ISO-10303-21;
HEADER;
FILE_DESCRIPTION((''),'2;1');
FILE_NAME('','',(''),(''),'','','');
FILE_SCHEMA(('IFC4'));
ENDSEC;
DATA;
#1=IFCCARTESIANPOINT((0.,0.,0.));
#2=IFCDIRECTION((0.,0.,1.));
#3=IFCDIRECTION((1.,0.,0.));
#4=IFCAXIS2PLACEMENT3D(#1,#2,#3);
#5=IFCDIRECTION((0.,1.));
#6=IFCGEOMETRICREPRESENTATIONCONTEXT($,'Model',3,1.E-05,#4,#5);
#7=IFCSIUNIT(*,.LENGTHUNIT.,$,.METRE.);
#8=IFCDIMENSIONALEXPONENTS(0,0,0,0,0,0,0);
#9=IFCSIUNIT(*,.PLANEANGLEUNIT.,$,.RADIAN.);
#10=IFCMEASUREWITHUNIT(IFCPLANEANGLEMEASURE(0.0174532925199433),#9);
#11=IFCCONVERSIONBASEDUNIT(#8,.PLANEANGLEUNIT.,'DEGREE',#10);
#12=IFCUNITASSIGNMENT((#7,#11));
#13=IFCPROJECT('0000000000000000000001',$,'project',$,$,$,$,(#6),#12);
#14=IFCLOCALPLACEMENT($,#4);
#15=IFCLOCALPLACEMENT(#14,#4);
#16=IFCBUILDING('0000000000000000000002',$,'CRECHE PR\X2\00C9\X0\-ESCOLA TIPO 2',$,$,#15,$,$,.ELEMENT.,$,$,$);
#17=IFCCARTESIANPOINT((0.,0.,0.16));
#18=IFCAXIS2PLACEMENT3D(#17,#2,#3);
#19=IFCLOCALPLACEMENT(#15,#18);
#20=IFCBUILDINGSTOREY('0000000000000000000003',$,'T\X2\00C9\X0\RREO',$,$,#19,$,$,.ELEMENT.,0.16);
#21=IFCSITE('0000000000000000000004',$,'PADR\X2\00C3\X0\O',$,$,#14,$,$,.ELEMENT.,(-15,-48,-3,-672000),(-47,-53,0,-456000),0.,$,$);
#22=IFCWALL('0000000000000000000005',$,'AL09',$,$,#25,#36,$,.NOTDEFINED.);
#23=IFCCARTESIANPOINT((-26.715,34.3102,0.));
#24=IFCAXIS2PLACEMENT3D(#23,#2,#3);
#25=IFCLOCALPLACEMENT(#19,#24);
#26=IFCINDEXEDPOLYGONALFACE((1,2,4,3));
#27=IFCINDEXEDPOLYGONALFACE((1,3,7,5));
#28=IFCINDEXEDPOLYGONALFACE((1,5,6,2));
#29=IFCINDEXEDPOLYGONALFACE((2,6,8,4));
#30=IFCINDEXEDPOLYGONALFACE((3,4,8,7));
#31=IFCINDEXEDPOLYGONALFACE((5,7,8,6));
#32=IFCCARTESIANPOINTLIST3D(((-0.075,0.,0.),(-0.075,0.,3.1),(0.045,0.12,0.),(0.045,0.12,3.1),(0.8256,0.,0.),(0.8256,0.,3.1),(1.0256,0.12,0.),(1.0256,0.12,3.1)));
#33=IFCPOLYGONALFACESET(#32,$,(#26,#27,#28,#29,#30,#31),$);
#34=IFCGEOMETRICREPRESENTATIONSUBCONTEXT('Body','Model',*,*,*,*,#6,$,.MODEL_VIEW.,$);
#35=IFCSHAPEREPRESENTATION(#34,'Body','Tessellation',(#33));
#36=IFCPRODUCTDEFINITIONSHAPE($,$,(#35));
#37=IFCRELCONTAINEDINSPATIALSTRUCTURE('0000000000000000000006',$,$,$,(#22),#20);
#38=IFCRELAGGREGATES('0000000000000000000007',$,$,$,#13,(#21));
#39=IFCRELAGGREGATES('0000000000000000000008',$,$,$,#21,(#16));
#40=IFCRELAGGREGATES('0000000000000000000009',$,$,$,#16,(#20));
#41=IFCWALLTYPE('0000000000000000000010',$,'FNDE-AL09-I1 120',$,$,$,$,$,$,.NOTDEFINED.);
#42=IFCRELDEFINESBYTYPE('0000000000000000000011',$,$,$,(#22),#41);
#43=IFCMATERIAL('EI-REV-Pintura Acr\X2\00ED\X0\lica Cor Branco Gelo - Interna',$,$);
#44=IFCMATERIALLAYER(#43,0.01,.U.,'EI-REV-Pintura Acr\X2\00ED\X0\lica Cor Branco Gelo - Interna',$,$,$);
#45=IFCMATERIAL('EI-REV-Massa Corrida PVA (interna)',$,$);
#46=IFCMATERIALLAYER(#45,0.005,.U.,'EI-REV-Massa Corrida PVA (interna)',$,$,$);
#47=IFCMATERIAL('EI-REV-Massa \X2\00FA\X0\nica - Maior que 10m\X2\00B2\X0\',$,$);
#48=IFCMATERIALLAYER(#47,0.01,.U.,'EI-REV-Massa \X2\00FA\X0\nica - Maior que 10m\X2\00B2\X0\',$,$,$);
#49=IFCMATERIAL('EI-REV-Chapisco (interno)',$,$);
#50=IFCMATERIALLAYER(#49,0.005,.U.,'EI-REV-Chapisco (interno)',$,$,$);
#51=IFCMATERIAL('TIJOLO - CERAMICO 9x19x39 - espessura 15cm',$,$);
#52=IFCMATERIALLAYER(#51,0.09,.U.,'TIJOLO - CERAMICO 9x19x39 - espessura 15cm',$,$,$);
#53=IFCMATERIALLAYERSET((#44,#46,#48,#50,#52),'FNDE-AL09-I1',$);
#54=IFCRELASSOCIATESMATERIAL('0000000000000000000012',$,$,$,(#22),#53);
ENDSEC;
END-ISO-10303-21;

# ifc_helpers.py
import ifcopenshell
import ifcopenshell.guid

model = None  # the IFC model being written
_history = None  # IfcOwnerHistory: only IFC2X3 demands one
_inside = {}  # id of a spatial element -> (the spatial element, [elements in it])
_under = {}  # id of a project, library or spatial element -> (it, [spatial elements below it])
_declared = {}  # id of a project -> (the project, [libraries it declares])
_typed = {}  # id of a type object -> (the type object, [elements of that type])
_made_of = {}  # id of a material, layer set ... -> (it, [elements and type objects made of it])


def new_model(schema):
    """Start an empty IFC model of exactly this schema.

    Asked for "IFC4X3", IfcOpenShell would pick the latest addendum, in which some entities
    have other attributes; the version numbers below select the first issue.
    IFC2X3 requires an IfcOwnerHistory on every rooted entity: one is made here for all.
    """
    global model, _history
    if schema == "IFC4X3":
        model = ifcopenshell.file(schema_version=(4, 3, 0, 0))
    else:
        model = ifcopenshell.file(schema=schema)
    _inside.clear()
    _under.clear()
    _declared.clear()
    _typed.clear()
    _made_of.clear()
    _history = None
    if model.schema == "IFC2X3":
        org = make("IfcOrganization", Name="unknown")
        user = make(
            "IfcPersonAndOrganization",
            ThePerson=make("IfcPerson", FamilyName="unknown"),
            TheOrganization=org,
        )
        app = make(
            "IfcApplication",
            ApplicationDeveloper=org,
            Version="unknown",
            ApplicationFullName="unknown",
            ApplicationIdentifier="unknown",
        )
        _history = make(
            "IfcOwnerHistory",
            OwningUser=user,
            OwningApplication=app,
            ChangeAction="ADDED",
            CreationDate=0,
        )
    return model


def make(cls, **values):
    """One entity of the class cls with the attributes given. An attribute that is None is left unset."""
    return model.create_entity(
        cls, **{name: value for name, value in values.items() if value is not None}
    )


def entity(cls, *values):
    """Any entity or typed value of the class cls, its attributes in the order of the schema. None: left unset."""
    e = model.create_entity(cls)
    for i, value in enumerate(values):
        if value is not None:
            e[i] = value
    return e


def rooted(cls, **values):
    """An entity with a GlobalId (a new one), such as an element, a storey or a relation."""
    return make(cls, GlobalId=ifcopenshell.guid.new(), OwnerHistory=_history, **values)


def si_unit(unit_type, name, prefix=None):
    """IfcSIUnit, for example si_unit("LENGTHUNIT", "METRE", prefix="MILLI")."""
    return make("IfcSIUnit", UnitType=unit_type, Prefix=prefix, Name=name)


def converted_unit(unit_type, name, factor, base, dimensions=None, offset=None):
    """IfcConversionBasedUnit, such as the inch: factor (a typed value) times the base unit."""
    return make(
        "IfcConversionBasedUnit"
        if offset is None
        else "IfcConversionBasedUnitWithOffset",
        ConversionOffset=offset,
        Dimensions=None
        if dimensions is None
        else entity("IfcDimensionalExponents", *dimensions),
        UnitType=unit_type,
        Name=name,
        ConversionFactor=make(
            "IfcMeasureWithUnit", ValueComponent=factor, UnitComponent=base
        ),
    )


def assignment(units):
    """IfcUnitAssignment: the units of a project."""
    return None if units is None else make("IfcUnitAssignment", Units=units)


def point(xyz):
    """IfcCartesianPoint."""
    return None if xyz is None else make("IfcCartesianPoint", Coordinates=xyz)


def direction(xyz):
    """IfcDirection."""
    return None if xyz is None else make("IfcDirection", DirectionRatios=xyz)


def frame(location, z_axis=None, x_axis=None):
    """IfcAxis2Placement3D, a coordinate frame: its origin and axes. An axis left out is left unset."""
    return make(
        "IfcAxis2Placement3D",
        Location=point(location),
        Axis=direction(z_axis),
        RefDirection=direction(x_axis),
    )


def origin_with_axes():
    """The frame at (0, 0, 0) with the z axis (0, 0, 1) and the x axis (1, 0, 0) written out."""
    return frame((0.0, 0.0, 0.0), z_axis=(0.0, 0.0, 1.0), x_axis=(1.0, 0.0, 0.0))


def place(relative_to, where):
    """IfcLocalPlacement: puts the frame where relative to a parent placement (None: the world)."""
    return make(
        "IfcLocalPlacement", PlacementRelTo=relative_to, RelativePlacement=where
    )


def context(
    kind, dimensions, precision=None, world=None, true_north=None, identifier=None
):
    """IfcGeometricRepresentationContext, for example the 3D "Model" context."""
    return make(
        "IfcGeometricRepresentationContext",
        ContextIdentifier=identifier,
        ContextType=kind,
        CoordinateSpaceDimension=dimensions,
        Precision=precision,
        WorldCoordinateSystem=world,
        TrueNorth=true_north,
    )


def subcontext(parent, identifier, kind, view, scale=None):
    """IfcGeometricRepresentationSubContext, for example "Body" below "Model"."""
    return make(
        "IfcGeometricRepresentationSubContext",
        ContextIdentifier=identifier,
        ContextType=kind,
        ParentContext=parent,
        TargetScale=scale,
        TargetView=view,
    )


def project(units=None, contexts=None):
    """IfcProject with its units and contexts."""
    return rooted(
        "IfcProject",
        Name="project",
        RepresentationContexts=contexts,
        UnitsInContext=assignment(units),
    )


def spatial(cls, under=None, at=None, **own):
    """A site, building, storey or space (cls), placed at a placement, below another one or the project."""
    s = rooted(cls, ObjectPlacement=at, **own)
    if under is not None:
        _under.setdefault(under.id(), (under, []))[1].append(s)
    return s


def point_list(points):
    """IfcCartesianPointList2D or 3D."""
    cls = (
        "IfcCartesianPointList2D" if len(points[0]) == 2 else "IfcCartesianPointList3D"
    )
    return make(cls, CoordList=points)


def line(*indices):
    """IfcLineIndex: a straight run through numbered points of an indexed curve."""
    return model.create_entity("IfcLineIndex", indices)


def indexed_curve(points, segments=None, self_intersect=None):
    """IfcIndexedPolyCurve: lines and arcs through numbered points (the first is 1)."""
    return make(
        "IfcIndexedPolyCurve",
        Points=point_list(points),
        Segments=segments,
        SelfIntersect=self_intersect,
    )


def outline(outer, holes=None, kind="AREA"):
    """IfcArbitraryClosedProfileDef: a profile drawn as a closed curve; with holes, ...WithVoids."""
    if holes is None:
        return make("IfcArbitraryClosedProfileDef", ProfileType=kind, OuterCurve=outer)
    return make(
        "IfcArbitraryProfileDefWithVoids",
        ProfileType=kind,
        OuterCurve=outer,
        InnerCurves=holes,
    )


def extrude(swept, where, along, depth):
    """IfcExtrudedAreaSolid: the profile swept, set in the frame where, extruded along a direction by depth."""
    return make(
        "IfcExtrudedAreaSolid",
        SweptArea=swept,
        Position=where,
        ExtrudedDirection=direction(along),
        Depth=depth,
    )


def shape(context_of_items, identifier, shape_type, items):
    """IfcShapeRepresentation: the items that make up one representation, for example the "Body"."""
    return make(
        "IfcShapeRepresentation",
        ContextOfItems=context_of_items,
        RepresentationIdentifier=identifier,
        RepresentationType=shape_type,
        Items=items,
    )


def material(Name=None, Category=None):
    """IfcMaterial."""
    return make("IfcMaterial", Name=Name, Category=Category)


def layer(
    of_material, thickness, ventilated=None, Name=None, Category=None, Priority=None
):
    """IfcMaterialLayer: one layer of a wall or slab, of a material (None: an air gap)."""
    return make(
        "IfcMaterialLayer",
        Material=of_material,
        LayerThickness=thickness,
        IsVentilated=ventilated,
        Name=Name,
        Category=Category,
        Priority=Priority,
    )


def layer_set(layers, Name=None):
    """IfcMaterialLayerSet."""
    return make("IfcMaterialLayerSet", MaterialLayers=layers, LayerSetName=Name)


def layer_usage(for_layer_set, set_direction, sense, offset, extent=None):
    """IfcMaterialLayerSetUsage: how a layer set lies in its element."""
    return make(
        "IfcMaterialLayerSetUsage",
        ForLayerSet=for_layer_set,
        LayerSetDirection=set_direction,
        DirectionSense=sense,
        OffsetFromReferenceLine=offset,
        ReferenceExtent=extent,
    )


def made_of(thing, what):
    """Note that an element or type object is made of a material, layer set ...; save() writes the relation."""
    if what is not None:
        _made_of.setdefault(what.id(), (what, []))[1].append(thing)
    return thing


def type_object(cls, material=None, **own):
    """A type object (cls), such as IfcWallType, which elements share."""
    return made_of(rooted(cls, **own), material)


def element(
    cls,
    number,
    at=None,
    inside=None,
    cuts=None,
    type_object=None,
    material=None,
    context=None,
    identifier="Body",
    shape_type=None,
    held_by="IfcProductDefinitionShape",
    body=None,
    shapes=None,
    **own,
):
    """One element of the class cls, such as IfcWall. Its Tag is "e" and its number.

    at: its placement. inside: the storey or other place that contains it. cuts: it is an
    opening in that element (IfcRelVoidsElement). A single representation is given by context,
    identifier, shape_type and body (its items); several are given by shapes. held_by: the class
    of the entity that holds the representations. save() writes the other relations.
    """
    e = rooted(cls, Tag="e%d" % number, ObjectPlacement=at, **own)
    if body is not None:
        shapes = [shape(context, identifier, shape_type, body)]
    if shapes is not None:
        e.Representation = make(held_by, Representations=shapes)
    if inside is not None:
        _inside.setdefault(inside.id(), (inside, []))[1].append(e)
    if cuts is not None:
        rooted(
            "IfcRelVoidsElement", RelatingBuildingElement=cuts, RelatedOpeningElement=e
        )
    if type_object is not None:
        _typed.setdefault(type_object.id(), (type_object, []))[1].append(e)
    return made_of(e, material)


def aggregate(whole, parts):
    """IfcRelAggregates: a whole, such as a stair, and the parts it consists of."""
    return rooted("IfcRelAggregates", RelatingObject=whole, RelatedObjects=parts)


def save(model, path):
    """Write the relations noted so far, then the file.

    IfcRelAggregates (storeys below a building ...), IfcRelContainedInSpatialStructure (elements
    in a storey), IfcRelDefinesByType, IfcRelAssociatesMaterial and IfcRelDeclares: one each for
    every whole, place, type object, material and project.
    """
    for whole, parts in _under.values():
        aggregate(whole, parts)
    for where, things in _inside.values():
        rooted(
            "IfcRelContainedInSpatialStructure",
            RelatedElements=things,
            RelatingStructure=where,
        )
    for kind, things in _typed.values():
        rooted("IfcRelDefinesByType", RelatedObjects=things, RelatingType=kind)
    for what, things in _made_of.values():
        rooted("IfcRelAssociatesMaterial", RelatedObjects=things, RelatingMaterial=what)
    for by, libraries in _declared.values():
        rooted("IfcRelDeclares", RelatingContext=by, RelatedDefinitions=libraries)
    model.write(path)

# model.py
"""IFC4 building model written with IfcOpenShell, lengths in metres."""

from ifc_helpers import new_model, entity, si_unit, converted_unit, direction, frame, origin_with_axes, place, context, subcontext, project, spatial, line, indexed_curve, outline, extrude, material, layer, layer_set, layer_usage, type_object, element, save


model = new_model("IFC4")

# Units and contexts
model_context = context("Model", 3, precision=1e-05, world=origin_with_axes(), true_north=direction((0.0, 1.0)))
body_context = subcontext(model_context, "Body", "Model", "MODEL_VIEW")
ifc_project = project(units=[si_unit("LENGTHUNIT", "METRE"), converted_unit("PLANEANGLEUNIT", "DEGREE", entity("IfcPlaneAngleMeasure", 0.0174532925199433), si_unit("PLANEANGLEUNIT", "RADIAN"), dimensions=[0, 0, 0, 0, 0, 0, 0])], contexts=[model_context])

# Site, building, storey
site_placement = place(None, origin_with_axes())
site = spatial("IfcSite", under=ifc_project, at=site_placement, Name="PADRÃO", CompositionType="ELEMENT", RefLatitude=(-15, -48, -3, -672000), RefLongitude=(-47, -53, 0, -456000), RefElevation=0.0)
building_placement = place(site_placement, origin_with_axes())
building = spatial("IfcBuilding", under=site, at=building_placement, Name="CRECHE PRÉ-ESCOLA TIPO 2", CompositionType="ELEMENT")
storey_placement = place(building_placement, frame((0.0, 0.0, 0.16), z_axis=(0.0, 0.0, 1.0), x_axis=(1.0, 0.0, 0.0)))
storey = spatial("IfcBuildingStorey", under=building, at=storey_placement, Name="TÉRREO", CompositionType="ELEMENT", Elevation=0.16)

# Shared definitions
ifc_material_1 = material(Name="TIJOLO - CERAMICO 9x19x39 - espessura 15cm")
ifc_material_2 = material(Name="EI-REV-Chapisco (interno)")
ifc_material_3 = material(Name="EI-REV-Massa única - Maior que 10m²")
ifc_material_4 = material(Name="EI-REV-Massa Corrida PVA (interna)")

# Shared definitions
ifc_material_5 = material(Name="EI-REV-Pintura Acrílica Cor Branco Gelo - Interna")

# Wall
ifc_layer_1 = layer(ifc_material_5, 0.01, ventilated="UNKNOWN", Name="EI-REV-Pintura Acrílica Cor Branco Gelo - Interna")
ifc_layer_2 = layer(ifc_material_4, 0.005, ventilated="UNKNOWN", Name="EI-REV-Massa Corrida PVA (interna)")
ifc_layer_3 = layer(ifc_material_3, 0.01, ventilated="UNKNOWN", Name="EI-REV-Massa única - Maior que 10m²")
ifc_layer_4 = layer(ifc_material_2, 0.005, ventilated="UNKNOWN", Name="EI-REV-Chapisco (interno)")
ifc_layer_5 = layer(ifc_material_1, 0.09, ventilated="UNKNOWN", Name="TIJOLO - CERAMICO 9x19x39 - espessura 15cm")
ifc_layer_set = layer_set([ifc_layer_1, ifc_layer_2, ifc_layer_3, ifc_layer_4, ifc_layer_5], Name="FNDE-AL09-I1")
ifc_layer_usage = layer_usage(ifc_layer_set, "AXIS2", "POSITIVE", 0.0)
wall_type_1 = type_object("IfcWallType", Name="FNDE-AL09-I1 120", PredefinedType="NOTDEFINED")
wall_1_placement = place(storey_placement, frame((-26.715, 34.3102, 0.0), z_axis=(0.0, 0.0, 1.0), x_axis=(1.0, 0.0, 0.0)))
element("IfcWall", 1, at=wall_1_placement, inside=storey, type_object=wall_type_1, material=ifc_layer_usage, Name="AL09", PredefinedType="NOTDEFINED", context=body_context, shape_type="SweptSolid", body=[
    extrude(outline(indexed_curve([(-0.075, 0.0), (0.8256, 0.0), (1.0256, 0.12), (0.045, 0.12)], segments=[line(1, 2, 3, 4, 1)])), origin_with_axes(), (0.0, 0.0, 1.0), 3.1),
])

save(model, "model.ifc")
